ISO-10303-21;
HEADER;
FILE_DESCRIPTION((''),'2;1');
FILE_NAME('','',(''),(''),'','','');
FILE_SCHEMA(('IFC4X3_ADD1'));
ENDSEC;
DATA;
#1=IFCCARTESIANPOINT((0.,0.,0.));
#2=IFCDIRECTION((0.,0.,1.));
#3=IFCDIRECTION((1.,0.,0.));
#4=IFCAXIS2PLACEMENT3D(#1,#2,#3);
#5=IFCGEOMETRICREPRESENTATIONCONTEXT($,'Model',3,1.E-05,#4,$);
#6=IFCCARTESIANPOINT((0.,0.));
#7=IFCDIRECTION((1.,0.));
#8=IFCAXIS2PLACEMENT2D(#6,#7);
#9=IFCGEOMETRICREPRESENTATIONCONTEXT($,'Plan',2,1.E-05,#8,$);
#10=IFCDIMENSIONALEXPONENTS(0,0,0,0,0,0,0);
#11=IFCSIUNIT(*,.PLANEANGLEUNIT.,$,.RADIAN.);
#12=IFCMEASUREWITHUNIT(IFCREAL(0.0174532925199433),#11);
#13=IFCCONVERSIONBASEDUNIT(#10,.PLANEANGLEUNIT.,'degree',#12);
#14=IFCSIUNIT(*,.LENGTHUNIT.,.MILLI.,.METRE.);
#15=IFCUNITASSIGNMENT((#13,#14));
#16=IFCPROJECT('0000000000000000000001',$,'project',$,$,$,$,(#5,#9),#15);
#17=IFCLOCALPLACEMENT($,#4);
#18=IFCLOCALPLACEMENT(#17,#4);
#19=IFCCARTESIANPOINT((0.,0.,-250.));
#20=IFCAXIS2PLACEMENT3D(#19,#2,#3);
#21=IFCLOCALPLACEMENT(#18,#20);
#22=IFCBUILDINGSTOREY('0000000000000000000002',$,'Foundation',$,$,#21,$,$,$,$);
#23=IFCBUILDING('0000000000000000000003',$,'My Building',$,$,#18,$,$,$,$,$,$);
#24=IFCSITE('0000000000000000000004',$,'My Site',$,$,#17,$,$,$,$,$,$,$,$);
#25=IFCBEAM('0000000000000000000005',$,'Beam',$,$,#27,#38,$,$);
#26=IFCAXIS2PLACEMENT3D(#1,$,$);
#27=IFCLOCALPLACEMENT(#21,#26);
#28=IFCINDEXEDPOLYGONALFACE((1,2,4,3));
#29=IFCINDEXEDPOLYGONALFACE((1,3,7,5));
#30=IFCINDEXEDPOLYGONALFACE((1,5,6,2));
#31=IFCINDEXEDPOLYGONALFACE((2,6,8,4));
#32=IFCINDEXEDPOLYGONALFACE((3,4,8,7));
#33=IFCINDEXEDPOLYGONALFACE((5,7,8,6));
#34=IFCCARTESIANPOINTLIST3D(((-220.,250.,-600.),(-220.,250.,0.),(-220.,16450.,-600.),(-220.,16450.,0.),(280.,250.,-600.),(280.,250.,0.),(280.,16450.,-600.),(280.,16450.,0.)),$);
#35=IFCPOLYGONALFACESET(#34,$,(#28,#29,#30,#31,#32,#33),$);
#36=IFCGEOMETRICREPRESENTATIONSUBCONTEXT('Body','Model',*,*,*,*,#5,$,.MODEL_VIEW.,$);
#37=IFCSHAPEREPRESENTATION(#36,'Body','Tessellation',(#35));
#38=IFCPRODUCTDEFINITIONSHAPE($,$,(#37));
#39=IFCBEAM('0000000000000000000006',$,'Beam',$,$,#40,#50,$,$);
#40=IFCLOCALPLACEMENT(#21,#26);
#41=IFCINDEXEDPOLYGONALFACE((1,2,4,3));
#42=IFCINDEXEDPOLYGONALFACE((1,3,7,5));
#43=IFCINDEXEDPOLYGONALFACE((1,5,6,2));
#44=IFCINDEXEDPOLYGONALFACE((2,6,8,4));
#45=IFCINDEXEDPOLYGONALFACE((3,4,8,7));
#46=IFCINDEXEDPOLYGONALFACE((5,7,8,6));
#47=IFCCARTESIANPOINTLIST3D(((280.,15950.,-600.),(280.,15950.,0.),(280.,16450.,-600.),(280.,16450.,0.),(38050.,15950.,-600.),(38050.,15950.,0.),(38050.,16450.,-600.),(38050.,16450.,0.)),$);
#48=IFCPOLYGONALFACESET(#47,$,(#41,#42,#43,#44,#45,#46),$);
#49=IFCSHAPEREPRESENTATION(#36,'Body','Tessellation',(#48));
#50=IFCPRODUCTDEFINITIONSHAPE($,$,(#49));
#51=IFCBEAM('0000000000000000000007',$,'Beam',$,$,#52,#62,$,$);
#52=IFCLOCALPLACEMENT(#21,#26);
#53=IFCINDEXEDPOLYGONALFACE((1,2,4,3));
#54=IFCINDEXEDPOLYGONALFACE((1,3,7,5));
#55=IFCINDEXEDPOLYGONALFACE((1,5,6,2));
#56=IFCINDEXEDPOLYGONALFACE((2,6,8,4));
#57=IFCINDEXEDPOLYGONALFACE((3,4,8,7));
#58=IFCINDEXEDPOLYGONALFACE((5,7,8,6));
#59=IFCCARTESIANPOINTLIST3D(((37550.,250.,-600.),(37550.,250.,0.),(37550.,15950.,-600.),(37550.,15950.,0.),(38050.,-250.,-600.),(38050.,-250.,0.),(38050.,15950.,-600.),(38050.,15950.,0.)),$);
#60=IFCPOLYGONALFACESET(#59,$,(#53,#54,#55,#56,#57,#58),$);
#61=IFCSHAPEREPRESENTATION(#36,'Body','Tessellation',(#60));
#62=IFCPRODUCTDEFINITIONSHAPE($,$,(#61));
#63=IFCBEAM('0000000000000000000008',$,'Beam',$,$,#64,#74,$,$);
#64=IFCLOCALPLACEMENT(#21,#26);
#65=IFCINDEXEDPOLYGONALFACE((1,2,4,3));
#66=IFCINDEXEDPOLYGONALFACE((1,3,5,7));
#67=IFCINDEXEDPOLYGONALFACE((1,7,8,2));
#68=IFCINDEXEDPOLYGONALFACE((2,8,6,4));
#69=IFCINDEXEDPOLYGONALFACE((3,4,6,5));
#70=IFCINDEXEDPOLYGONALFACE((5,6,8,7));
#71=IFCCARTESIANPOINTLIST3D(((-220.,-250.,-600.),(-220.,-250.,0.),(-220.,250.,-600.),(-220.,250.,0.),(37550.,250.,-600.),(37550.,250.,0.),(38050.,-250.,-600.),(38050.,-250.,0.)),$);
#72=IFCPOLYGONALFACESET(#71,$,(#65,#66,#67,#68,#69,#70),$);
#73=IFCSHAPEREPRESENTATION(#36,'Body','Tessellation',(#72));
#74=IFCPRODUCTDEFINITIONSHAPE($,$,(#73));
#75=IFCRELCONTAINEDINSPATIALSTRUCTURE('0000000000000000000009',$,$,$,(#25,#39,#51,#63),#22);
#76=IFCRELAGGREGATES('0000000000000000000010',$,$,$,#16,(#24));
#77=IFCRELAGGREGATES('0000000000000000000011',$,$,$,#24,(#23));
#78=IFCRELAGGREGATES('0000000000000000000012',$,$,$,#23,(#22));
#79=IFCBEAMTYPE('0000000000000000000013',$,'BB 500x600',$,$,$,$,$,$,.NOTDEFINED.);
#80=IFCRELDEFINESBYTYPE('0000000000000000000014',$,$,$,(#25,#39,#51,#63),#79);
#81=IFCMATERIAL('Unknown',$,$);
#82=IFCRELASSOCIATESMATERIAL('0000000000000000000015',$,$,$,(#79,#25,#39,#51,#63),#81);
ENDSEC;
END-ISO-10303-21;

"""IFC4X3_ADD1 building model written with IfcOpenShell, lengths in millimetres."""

from ifc_helpers import new_model, entity, si_unit, converted_unit, frame, origin_with_axes, origin_2d_with_axis, place, context, subcontext, project, spatial, rectangle, extrude, clip, halfspace, material, material_profile, profile_set, profile_usage, type_object, element, save


model = new_model("IFC4X3_ADD1")

# Units and contexts
model_context = context("Model", 3, precision=1e-05, world=origin_with_axes())
plan_context = context("Plan", 2, precision=1e-05, world=origin_2d_with_axis())
body_context = subcontext(model_context, "Body", "Model", "MODEL_VIEW")
ifc_project = project(units=[converted_unit("PLANEANGLEUNIT", "degree", entity("IfcReal", 0.0174532925199433), si_unit("PLANEANGLEUNIT", "RADIAN"), dimensions=[0, 0, 0, 0, 0, 0, 0]), si_unit("LENGTHUNIT", "METRE", prefix="MILLI")], contexts=[model_context, plan_context])

# Site, building, storey
site_placement = place(None, origin_with_axes())
site = spatial("IfcSite", under=ifc_project, at=site_placement, Name="My Site")
building_placement = place(site_placement, origin_with_axes())
building = spatial("IfcBuilding", under=site, at=building_placement, Name="My Building")
storey_placement = place(building_placement, frame((0.0, 0.0, -250.0), z_axis=(0.0, 0.0, 1.0), x_axis=(1.0, 0.0, 0.0)))
storey = spatial("IfcBuildingStorey", under=building, at=storey_placement, Name="Foundation")

# Beams
ifc_material = material(Name="Unknown")
ifc_material_profile = material_profile(ifc_material, rectangle(XDim=500.0, YDim=600.0))
ifc_profile_set = profile_set([ifc_material_profile])
ifc_profile_usage_1 = profile_usage(ifc_profile_set, cardinal=8)
beam_type = type_object("IfcBeamType", Name="BB 500x600", PredefinedType="NOTDEFINED", material=ifc_profile_set)
beam_1_placement = place(storey_placement, frame((30.0, 250.0, 0.0), z_axis=(0.0, 1.0, 0.0), x_axis=(-1.0, 0.0, 0.0)))
element("IfcBeam", 1, at=beam_1_placement, inside=storey, type_object=beam_type, material=ifc_profile_usage_1, Name="Beam", context=body_context, shape_type="SweptSolid", body=[
    extrude(rectangle(XDim=500.0, YDim=600.0), frame((0.0, -300.0, 0.0), z_axis=(0.0, 0.0, 1.0), x_axis=(1.0, 0.0, 0.0)), (0.0, 0.0, 1.0), 16200.0),
])
ifc_profile_usage_2 = profile_usage(ifc_profile_set, cardinal=8)
beam_2_placement = place(storey_placement, frame((280.0, 16200.0, 0.0), z_axis=(1.0, 0.0, 0.0), x_axis=(0.0, 1.0, 0.0)))
element("IfcBeam", 2, at=beam_2_placement, inside=storey, type_object=beam_type, material=ifc_profile_usage_2, Name="Beam", context=body_context, shape_type="SweptSolid", body=[
    extrude(rectangle(XDim=500.0, YDim=600.0), frame((0.0, -300.0, 0.0), z_axis=(0.0, 0.0, 1.0), x_axis=(1.0, 0.0, 0.0)), (0.0, 0.0, 1.0), 37770.0),
])
ifc_profile_usage_3 = profile_usage(ifc_profile_set, cardinal=8)
beam_3_placement = place(storey_placement, frame((37800.0, -250.0, 0.0), z_axis=(0.0, 1.0, 0.0), x_axis=(-1.0, 0.0, 0.0)))
element("IfcBeam", 3, at=beam_3_placement, inside=storey, type_object=beam_type, material=ifc_profile_usage_3, Name="Beam", context=body_context, shape_type="Clipping", body=[
    clip(extrude(rectangle(XDim=500.0, YDim=600.0), frame((0.0, -300.0, 0.0), z_axis=(0.0, 0.0, 1.0), x_axis=(1.0, 0.0, 0.0)), (0.0, 0.0, 1.0), 16200.0), halfspace(frame((-250.0, 250.0, 0.0), z_axis=(0.707107, 0.0, -0.707107), x_axis=(0.707107, 0.0, 0.707107)), False)),
])
ifc_profile_usage_4 = profile_usage(ifc_profile_set, cardinal=8)
beam_4_placement = place(storey_placement, frame((-220.0, 0.0, 0.0), z_axis=(1.0, 0.0, 0.0), x_axis=(0.0, 1.0, 0.0)))
element("IfcBeam", 4, at=beam_4_placement, inside=storey, type_object=beam_type, material=ifc_profile_usage_4, Name="Beam", context=body_context, shape_type="Clipping", body=[
    clip(extrude(rectangle(XDim=500.0, YDim=600.0), frame((0.0, -300.0, 0.0), z_axis=(0.0, 0.0, 1.0), x_axis=(1.0, 0.0, 0.0)), (0.0, 0.0, 1.0), 38270.0), halfspace(frame((-250.0, 250.0, 38270.0), z_axis=(0.707107, 0.0, 0.707107), x_axis=(0.707107, 0.0, -0.707107)), False)),
])

save(model, "model.ifc")
